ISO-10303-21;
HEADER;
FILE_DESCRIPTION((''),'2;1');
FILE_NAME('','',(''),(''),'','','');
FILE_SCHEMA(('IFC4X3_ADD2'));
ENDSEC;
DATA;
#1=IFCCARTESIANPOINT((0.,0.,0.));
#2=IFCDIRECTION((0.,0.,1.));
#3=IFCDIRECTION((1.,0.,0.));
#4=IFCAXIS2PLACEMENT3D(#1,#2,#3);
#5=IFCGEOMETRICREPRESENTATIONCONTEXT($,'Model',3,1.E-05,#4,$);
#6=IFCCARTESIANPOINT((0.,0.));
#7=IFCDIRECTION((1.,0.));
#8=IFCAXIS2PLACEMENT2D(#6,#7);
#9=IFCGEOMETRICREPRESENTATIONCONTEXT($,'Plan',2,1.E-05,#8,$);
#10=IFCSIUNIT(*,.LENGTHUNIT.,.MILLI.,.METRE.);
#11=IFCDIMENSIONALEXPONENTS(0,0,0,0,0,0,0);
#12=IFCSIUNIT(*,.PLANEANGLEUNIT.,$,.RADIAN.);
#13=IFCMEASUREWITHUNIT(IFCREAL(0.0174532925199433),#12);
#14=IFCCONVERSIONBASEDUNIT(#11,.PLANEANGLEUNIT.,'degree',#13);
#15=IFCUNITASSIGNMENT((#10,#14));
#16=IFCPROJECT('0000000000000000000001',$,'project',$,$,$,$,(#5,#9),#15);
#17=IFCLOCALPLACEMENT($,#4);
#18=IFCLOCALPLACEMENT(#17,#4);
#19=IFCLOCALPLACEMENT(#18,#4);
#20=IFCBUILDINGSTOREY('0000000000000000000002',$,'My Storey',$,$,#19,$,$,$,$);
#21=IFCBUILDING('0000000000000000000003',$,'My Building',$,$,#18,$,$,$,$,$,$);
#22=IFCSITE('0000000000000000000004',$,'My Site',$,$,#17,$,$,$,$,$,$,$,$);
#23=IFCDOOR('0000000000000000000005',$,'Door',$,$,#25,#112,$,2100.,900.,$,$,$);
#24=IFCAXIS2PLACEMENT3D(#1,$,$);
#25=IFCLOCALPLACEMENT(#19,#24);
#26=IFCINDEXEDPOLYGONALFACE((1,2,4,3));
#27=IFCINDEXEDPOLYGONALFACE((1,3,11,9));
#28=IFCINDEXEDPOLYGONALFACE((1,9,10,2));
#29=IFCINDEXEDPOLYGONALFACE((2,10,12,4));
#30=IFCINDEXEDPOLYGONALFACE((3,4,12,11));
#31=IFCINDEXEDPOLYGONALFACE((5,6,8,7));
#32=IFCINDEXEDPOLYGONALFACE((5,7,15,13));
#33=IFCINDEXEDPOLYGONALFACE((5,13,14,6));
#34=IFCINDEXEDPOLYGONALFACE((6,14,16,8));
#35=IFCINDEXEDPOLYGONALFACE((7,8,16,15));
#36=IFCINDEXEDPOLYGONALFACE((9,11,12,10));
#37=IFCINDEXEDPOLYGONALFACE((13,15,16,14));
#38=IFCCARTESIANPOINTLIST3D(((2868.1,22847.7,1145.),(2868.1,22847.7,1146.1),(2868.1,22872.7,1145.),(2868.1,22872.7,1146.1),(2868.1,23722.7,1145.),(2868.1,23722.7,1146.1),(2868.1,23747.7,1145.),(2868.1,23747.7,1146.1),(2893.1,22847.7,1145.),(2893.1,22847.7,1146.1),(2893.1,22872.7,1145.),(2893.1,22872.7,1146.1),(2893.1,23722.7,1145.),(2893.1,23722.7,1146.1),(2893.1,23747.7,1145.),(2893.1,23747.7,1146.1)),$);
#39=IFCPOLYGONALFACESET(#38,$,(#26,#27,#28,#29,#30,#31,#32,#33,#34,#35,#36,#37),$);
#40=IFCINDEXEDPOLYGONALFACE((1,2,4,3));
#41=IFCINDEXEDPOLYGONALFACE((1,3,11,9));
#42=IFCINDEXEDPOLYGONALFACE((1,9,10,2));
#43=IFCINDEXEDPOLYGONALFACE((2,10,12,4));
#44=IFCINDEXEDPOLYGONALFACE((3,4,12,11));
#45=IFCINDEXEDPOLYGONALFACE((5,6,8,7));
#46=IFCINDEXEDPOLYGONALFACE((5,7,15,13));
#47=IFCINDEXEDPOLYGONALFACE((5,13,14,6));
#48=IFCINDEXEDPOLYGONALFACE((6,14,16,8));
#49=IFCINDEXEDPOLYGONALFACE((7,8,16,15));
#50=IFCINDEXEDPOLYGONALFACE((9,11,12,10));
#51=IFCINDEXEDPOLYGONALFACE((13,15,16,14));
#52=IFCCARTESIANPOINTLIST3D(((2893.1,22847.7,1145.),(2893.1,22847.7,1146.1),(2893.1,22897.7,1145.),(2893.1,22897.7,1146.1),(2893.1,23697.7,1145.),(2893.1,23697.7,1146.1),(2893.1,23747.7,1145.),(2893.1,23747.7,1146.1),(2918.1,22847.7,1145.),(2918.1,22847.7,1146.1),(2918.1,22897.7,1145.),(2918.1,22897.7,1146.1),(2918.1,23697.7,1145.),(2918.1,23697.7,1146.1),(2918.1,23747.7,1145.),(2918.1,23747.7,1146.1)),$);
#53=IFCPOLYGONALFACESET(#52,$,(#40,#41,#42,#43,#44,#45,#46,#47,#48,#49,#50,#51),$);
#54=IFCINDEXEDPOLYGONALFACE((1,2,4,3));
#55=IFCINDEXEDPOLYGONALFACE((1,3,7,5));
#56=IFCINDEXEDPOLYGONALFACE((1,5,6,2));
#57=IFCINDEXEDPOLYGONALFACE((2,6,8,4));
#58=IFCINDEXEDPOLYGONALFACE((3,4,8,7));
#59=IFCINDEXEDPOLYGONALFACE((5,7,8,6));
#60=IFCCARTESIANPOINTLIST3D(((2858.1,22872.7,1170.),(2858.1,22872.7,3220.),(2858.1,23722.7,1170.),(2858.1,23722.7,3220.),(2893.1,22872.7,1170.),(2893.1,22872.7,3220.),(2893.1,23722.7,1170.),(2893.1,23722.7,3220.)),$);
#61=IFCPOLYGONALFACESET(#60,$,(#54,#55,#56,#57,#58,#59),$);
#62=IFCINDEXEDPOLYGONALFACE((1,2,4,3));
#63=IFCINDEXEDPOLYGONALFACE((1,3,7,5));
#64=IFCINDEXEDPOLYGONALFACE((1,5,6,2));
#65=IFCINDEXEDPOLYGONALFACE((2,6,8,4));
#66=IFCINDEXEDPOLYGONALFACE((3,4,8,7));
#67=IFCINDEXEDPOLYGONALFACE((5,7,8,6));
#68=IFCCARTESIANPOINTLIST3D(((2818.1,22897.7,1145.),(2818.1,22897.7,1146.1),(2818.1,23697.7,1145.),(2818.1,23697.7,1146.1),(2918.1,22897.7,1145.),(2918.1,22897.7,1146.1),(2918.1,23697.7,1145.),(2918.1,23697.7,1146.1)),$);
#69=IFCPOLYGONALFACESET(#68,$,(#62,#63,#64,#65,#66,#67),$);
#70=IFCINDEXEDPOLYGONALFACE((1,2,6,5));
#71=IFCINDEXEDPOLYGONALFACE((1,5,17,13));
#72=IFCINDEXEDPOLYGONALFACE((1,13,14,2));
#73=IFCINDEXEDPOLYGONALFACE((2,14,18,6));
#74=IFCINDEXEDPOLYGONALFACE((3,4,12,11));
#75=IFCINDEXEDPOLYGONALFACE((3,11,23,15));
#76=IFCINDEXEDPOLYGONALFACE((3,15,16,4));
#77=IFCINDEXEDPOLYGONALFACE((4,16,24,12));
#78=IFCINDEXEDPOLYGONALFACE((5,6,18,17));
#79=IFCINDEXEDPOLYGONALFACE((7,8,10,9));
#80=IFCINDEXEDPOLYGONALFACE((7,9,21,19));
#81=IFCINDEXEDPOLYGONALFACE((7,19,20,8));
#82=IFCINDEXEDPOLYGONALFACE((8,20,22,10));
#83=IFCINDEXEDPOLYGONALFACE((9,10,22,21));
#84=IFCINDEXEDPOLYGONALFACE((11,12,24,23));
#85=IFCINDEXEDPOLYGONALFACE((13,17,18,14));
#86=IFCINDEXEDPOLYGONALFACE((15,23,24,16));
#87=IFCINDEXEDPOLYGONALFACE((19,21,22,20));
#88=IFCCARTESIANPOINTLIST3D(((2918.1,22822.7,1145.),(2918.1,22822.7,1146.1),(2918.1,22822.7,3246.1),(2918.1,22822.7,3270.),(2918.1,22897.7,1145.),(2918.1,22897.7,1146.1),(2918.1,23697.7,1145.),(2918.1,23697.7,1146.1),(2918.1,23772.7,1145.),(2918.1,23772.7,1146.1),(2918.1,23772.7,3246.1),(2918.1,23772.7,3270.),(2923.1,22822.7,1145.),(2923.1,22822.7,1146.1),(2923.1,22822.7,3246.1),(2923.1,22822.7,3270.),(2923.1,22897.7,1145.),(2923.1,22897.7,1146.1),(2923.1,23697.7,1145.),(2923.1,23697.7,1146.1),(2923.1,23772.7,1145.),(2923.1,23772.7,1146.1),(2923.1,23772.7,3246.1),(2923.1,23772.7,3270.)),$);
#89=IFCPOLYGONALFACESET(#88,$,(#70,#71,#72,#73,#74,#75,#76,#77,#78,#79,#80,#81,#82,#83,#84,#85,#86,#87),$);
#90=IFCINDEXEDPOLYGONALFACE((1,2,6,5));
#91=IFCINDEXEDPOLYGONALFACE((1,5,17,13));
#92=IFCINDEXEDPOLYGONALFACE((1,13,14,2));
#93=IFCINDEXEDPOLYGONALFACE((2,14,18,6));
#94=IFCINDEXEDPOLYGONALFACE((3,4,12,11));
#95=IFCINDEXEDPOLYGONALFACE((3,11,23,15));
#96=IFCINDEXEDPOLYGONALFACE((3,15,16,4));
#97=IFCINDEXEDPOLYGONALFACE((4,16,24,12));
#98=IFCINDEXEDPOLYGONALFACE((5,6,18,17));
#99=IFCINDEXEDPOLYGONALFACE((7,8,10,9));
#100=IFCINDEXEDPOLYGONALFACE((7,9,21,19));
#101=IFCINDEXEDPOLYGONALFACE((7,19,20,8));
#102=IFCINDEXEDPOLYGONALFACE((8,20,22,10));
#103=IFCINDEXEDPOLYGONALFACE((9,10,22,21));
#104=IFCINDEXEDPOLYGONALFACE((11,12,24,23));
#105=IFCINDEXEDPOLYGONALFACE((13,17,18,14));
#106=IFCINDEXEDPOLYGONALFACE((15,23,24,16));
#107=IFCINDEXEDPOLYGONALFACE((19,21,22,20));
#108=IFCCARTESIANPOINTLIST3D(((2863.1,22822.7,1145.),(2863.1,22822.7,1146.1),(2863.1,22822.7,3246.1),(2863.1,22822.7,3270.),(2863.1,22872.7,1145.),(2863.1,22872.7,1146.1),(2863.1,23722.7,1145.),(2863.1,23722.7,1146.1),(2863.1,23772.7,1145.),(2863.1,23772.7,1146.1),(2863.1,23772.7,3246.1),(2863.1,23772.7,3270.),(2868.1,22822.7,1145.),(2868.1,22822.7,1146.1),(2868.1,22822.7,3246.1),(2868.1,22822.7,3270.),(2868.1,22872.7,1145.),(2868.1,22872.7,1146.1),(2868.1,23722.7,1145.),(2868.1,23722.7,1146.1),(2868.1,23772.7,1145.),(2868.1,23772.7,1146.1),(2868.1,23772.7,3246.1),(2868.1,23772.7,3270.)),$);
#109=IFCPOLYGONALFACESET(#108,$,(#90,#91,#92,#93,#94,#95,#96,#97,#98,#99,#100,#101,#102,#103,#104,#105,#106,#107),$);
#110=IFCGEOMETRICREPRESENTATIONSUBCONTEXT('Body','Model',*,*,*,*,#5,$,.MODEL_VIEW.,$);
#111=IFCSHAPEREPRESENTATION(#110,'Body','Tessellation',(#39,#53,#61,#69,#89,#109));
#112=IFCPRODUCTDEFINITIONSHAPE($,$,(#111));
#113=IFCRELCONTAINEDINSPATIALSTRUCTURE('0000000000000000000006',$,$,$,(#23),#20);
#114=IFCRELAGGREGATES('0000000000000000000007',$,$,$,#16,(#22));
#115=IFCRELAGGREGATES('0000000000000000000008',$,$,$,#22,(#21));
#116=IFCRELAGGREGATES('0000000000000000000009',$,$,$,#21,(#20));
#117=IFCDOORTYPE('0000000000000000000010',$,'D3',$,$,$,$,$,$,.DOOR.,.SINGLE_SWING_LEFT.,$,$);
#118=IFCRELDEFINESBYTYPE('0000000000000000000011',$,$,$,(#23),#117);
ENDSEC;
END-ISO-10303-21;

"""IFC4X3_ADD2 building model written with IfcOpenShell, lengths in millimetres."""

from ifc_helpers import new_model, entity, si_unit, converted_unit, frame, origin_with_axes, origin_2d_with_axis, place, context, subcontext, project, spatial, line, indexed_curve, outline, extrude, shape, source, transform, mapped, type_object, type_shapes, element, save


model = new_model("IFC4X3_ADD2")

# Units and contexts
model_context = context("Model", 3, precision=1e-05, world=origin_with_axes())
plan_context = context("Plan", 2, precision=1e-05, world=origin_2d_with_axis())
body_context_1 = subcontext(model_context, "Body", "Model", "MODEL_VIEW")
body_context_2 = subcontext(plan_context, "Body", "Plan", "PLAN_VIEW")
ifc_project = project(units=[si_unit("LENGTHUNIT", "METRE", prefix="MILLI"), converted_unit("PLANEANGLEUNIT", "degree", entity("IfcReal", 0.0174532925199433), si_unit("PLANEANGLEUNIT", "RADIAN"), dimensions=[0, 0, 0, 0, 0, 0, 0])], contexts=[model_context, plan_context])

# Site, building, storey
site_placement = place(None, origin_with_axes())
site = spatial("IfcSite", under=ifc_project, at=site_placement, Name="My Site")
building_placement = place(site_placement, origin_with_axes())
building = spatial("IfcBuilding", under=site, at=building_placement, Name="My Building")
storey_placement = place(building_placement, origin_with_axes())
storey = spatial("IfcBuildingStorey", under=building, at=storey_placement, Name="My Storey")

# Door, opening
door_type = type_object("IfcDoorType", Name="D3", OperationType="SINGLE_SWING_LEFT", PredefinedType="DOOR")
shared_shape_1 = source(origin_with_axes(), body_context_1, "Body", "SweptSolid", [
    extrude(outline(indexed_curve([(0.0, 0.0), (0.0, 2100.0), (900.0, 2100.0), (900.0, 0.0), (875.0, 0.0), (875.0, 2075.0), (25.0, 2075.0), (25.0, 0.0)], segments=[line(1, 2, 3, 4, 5, 6, 7, 8, 1)])), frame((0.0, 25.0, 0.0), z_axis=(0.0, -1.0, 0.0), x_axis=(1.0, 0.0, 0.0)), (0.0, 0.0, -1.0), 25.0),
    extrude(outline(indexed_curve([(0.0, 0.0), (0.0, 2100.0), (900.0, 2100.0), (900.0, 0.0), (850.0, 0.0), (850.0, 2050.0), (50.0, 2050.0), (50.0, 0.0)], segments=[line(1, 2, 3, 4, 5, 6, 7, 8, 1)])), frame((0.0, 0.0, 0.0), z_axis=(0.0, -1.0, 0.0), x_axis=(1.0, 0.0, 0.0)), (0.0, 0.0, -1.0), 25.0),
    extrude(outline(indexed_curve([(0.0, 0.0), (850.0, 0.0), (850.0, 35.0), (0.0, 35.0)], segments=[line(1, 2, 3, 4, 1)])), frame((25.0, 25.0, 25.0), z_axis=(0.0, 0.0, 1.0), x_axis=(1.0, 0.0, 0.0)), (0.0, 0.0, 1.0), 2050.0),
    extrude(outline(indexed_curve([(0.0, 0.0), (0.0, -40.0), (-120.0, -40.0), (-120.0, -20.0), (-20.0, -20.0), (-20.0, 0.0)], segments=[line(1, 2, 3, 4, 5, 6, 1)])), frame((825.0, 25.0, 1015.0), z_axis=(0.0, 0.0, 1.0), x_axis=(1.0, 0.0, 0.0)), (0.0, 0.0, 1.0), 20.0),
    extrude(outline(indexed_curve([(0.0, 0.0), (0.0, 40.0), (-120.0, 40.0), (-120.0, 20.0), (-20.0, 20.0), (-20.0, 0.0)], segments=[line(1, 2, 3, 4, 5, 6, 1)])), frame((825.0, 60.0, 1015.0), z_axis=(0.0, 0.0, 1.0), x_axis=(1.0, 0.0, 0.0)), (0.0, 0.0, 1.0), 20.0),
    extrude(outline(indexed_curve([(0.0, 0.0), (800.0, 0.0), (800.0, 100.0), (0.0, 100.0)], segments=[line(1, 2, 3, 4, 1)])), frame((50.0, 0.0, 0.0), z_axis=(0.0, 0.0, 1.0), x_axis=(1.0, 0.0, 0.0)), (0.0, 0.0, 1.0), 25.0),
    extrude(outline(indexed_curve([(0.0, 0.0), (0.0, 2125.0), (950.0, 2125.0), (950.0, 0.0), (875.0, 0.0), (875.0, 2050.0), (75.0, 2050.0), (75.0, 0.0)], segments=[line(1, 2, 3, 4, 5, 6, 7, 8, 1)])), frame((-25.0, -5.0, 0.0), z_axis=(0.0, -1.0, 0.0), x_axis=(1.0, 0.0, 0.0)), (0.0, 0.0, -1.0), 5.0),
    extrude(outline(indexed_curve([(0.0, 0.0), (0.0, 2125.0), (950.0, 2125.0), (950.0, 0.0), (900.0, 0.0), (900.0, 2075.0), (50.0, 2075.0), (50.0, 0.0)], segments=[line(1, 2, 3, 4, 5, 6, 7, 8, 1)])), frame((-25.0, 50.0, 0.0), z_axis=(0.0, -1.0, 0.0), x_axis=(1.0, 0.0, 0.0)), (0.0, 0.0, -1.0), 5.0),
])
shared_shape_2 = source(origin_with_axes(), body_context_2, "Body", "Curve2D", [
    entity("IfcIndexedPolyCurve", entity("IfcCartesianPointList2D", [[0.0, 0.0], [0.0, 50.0], [25.0, 50.0], [25.0, 25.0], [50.0, 25.0], [50.0, 0.0]]), [entity("IfcLineIndex", [1, 2, 3, 4, 5, 6, 1])]),
    entity("IfcIndexedPolyCurve", entity("IfcCartesianPointList2D", [[900.0, 0.0], [900.0, 50.0], [875.0, 50.0], [875.0, 25.0], [850.0, 25.0], [850.0, 0.0]]), [entity("IfcLineIndex", [1, 2, 3, 4, 5, 6, 1])]),
    entity("IfcTrimmedCurve", entity("IfcEllipse", entity("IfcAxis2Placement2D", entity("IfcCartesianPoint", [60.0, 50.0]), entity("IfcDirection", [1.0, 0.0])), 815.0, 850.0), [entity("IfcCartesianPoint", [875.0, 50.0])], [entity("IfcCartesianPoint", [60.0, 900.0])], True, "CARTESIAN"),
    entity("IfcIndexedPolyCurve", entity("IfcCartesianPointList2D", [[25.0, 50.0], [60.0, 50.0], [60.0, 900.0], [25.0, 900.0]]), [entity("IfcLineIndex", [1, 2, 3, 4, 1])]),
])
type_shapes(door_type, [shared_shape_1, shared_shape_2])
door_placement = place(storey_placement, frame((2918.1, 22847.7, 1145.0), z_axis=(0.0, 0.0, 1.0), x_axis=(0.0, 1.0, 0.0)))
door = element("IfcDoor", 1, at=door_placement, inside=storey, type_object=door_type, Name="Door", OverallHeight=2100.0, OverallWidth=900.0, shapes=[
    shape(body_context_1, "Body", "MappedRepresentation", [mapped(shared_shape_1, transform((0.0, 0.0, 0.0), x_axis=(1.0, 0.0, 0.0), y_axis=(0.0, 1.0, 0.0), z_axis=(0.0, 0.0, 1.0), scale=1.0))]),
    shape(body_context_2, "Body", "MappedRepresentation", [mapped(shared_shape_2, transform((0.0, 0.0, 0.0), x_axis=(1.0, 0.0, 0.0), y_axis=(0.0, 1.0, 0.0), z_axis=(0.0, 0.0, 1.0), scale=1.0))]),
])
opening_1_placement = place(door_placement, frame((-25.0, 326.8, 1.1), z_axis=(0.0, 0.0, 1.0), x_axis=(0.0, -1.0, 0.0)))
element("IfcOpeningElement", 2, at=opening_1_placement, cuts=door, PredefinedType="OPENING", context=body_context_1, shape_type="SweptSolid", body=[
    extrude(outline(indexed_curve([(0.0, 0.0), (500.0, 0.0), (500.0, 950.0), (0.0, 950.0), (0.0, 0.0)])), origin_with_axes(), (0.0, 0.0, 1.0), 2100.0),
])

save(model, "model.ifc")
